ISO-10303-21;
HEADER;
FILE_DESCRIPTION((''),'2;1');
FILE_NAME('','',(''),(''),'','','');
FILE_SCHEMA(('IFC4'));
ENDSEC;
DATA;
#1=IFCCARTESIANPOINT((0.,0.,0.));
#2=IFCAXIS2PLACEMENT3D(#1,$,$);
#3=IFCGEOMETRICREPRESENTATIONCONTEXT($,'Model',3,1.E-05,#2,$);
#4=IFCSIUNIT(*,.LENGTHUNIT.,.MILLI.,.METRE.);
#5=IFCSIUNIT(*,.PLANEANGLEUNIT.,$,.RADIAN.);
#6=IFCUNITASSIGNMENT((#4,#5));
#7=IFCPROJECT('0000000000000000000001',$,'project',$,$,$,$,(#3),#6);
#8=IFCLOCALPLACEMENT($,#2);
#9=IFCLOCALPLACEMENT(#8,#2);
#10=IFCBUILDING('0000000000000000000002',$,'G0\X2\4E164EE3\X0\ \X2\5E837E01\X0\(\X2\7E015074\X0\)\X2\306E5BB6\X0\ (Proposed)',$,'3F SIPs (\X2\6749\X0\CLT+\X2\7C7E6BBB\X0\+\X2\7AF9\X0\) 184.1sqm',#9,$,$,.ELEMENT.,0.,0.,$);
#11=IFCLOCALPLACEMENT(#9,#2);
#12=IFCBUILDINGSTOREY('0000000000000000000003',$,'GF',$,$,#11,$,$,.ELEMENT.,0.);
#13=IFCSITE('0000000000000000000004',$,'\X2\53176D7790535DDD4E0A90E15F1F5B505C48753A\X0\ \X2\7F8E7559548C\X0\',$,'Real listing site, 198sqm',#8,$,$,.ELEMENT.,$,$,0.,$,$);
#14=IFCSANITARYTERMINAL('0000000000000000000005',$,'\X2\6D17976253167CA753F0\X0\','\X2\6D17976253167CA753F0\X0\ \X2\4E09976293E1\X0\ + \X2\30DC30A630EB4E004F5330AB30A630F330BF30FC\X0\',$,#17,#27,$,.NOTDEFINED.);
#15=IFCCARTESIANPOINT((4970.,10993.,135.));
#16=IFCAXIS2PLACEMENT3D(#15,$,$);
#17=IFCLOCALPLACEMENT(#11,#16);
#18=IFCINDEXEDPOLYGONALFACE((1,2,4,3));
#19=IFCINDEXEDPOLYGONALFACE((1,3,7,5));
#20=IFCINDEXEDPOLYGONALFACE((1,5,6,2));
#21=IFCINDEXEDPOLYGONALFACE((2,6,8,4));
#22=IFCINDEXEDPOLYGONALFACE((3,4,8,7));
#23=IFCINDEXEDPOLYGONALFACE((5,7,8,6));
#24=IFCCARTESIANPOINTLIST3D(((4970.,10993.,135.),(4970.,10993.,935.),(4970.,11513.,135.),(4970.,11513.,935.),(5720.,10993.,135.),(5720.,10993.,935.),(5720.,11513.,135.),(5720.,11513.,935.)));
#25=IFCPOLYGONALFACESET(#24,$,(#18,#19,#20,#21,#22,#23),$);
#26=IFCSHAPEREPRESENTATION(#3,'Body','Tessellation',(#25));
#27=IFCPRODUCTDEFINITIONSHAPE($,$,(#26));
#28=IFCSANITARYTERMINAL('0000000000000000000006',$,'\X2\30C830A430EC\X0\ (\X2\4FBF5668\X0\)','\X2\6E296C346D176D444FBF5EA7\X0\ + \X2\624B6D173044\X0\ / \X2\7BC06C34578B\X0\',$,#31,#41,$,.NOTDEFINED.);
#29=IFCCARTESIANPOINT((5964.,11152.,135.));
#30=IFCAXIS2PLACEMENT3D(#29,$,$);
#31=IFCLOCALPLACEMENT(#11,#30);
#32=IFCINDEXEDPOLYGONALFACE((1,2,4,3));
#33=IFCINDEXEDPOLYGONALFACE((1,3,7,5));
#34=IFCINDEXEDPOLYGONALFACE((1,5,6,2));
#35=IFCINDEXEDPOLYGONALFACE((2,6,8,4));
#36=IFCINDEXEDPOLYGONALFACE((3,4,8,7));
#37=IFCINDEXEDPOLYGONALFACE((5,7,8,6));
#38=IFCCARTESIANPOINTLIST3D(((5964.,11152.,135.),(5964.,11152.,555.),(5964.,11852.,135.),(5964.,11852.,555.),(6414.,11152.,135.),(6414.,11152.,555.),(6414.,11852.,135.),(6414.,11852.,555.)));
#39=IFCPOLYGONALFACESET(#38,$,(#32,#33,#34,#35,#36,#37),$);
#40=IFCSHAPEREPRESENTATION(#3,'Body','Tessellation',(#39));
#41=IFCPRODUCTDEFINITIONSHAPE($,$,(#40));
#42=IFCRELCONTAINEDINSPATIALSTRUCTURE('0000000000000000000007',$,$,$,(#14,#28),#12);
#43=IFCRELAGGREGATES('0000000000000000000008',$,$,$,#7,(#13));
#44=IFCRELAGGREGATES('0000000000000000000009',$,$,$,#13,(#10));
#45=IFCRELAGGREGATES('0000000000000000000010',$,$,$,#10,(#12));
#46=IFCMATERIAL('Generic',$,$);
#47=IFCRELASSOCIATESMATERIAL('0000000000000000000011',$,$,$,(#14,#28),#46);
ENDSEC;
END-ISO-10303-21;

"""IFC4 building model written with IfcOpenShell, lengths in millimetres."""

from ifc_helpers import new_model, si_unit, frame, frame_2d, origin, place, context, project, spatial, rectangle, extrude, material, element, save


model = new_model("IFC4")

# Units and contexts
model_context = context("Model", 3, precision=1e-05, world=origin())
ifc_project = project(units=[si_unit("LENGTHUNIT", "METRE", prefix="MILLI"), si_unit("PLANEANGLEUNIT", "RADIAN")], contexts=[model_context])

# Site, building, storey
site_placement = place(None, origin())
site = spatial("IfcSite", under=ifc_project, at=site_placement, Name="北海道川上郡弟子屈町 美留和", ObjectType="Real listing site, 198sqm", CompositionType="ELEMENT", RefElevation=0.0)
building_placement = place(site_placement, origin())
building = spatial("IfcBuilding", under=site, at=building_placement, Name="G0世代 広縁(縁側)の家 (Proposed)", ObjectType="3F SIPs (杉CLT+籾殻+竹) 184.1sqm", CompositionType="ELEMENT", ElevationOfRefHeight=0.0, ElevationOfTerrain=0.0)
storey_placement = place(building_placement, origin())
storey = spatial("IfcBuildingStorey", under=building, at=storey_placement, Name="GF", CompositionType="ELEMENT", Elevation=0.0)

# Shared definitions
ifc_material_1 = material(Name="Generic")

# Sanitary terminals
sanitary_terminal_1_placement = place(storey_placement, frame((4970.0, 10993.0, 135.0)))
element("IfcSanitaryTerminal", 1, at=sanitary_terminal_1_placement, inside=storey, material=ifc_material_1, Name="洗面化粧台", Description="洗面化粧台 三面鏡 + ボウル一体カウンター", PredefinedType="NOTDEFINED", context=model_context, shape_type="SweptSolid", body=[
    extrude(rectangle(XDim=750.0, YDim=520.0, at=frame_2d((375.0, 260.0))), frame((4970.0, 10993.0, 135.0)), (0.0, 0.0, 1.0), 800.0),
])
sanitary_terminal_2_placement = place(storey_placement, frame((5964.0, 11152.0, 135.0)))
element("IfcSanitaryTerminal", 2, at=sanitary_terminal_2_placement, inside=storey, material=ifc_material_1, Name="トイレ (便器)", Description="温水洗浄便座 + 手洗い / 節水型", PredefinedType="NOTDEFINED", context=model_context, shape_type="SweptSolid", body=[
    extrude(rectangle(XDim=450.0, YDim=700.0, at=frame_2d((225.0, 350.0))), frame((5964.0, 11152.0, 135.0)), (0.0, 0.0, 1.0), 420.0),
])

save(model, "model.ifc")
